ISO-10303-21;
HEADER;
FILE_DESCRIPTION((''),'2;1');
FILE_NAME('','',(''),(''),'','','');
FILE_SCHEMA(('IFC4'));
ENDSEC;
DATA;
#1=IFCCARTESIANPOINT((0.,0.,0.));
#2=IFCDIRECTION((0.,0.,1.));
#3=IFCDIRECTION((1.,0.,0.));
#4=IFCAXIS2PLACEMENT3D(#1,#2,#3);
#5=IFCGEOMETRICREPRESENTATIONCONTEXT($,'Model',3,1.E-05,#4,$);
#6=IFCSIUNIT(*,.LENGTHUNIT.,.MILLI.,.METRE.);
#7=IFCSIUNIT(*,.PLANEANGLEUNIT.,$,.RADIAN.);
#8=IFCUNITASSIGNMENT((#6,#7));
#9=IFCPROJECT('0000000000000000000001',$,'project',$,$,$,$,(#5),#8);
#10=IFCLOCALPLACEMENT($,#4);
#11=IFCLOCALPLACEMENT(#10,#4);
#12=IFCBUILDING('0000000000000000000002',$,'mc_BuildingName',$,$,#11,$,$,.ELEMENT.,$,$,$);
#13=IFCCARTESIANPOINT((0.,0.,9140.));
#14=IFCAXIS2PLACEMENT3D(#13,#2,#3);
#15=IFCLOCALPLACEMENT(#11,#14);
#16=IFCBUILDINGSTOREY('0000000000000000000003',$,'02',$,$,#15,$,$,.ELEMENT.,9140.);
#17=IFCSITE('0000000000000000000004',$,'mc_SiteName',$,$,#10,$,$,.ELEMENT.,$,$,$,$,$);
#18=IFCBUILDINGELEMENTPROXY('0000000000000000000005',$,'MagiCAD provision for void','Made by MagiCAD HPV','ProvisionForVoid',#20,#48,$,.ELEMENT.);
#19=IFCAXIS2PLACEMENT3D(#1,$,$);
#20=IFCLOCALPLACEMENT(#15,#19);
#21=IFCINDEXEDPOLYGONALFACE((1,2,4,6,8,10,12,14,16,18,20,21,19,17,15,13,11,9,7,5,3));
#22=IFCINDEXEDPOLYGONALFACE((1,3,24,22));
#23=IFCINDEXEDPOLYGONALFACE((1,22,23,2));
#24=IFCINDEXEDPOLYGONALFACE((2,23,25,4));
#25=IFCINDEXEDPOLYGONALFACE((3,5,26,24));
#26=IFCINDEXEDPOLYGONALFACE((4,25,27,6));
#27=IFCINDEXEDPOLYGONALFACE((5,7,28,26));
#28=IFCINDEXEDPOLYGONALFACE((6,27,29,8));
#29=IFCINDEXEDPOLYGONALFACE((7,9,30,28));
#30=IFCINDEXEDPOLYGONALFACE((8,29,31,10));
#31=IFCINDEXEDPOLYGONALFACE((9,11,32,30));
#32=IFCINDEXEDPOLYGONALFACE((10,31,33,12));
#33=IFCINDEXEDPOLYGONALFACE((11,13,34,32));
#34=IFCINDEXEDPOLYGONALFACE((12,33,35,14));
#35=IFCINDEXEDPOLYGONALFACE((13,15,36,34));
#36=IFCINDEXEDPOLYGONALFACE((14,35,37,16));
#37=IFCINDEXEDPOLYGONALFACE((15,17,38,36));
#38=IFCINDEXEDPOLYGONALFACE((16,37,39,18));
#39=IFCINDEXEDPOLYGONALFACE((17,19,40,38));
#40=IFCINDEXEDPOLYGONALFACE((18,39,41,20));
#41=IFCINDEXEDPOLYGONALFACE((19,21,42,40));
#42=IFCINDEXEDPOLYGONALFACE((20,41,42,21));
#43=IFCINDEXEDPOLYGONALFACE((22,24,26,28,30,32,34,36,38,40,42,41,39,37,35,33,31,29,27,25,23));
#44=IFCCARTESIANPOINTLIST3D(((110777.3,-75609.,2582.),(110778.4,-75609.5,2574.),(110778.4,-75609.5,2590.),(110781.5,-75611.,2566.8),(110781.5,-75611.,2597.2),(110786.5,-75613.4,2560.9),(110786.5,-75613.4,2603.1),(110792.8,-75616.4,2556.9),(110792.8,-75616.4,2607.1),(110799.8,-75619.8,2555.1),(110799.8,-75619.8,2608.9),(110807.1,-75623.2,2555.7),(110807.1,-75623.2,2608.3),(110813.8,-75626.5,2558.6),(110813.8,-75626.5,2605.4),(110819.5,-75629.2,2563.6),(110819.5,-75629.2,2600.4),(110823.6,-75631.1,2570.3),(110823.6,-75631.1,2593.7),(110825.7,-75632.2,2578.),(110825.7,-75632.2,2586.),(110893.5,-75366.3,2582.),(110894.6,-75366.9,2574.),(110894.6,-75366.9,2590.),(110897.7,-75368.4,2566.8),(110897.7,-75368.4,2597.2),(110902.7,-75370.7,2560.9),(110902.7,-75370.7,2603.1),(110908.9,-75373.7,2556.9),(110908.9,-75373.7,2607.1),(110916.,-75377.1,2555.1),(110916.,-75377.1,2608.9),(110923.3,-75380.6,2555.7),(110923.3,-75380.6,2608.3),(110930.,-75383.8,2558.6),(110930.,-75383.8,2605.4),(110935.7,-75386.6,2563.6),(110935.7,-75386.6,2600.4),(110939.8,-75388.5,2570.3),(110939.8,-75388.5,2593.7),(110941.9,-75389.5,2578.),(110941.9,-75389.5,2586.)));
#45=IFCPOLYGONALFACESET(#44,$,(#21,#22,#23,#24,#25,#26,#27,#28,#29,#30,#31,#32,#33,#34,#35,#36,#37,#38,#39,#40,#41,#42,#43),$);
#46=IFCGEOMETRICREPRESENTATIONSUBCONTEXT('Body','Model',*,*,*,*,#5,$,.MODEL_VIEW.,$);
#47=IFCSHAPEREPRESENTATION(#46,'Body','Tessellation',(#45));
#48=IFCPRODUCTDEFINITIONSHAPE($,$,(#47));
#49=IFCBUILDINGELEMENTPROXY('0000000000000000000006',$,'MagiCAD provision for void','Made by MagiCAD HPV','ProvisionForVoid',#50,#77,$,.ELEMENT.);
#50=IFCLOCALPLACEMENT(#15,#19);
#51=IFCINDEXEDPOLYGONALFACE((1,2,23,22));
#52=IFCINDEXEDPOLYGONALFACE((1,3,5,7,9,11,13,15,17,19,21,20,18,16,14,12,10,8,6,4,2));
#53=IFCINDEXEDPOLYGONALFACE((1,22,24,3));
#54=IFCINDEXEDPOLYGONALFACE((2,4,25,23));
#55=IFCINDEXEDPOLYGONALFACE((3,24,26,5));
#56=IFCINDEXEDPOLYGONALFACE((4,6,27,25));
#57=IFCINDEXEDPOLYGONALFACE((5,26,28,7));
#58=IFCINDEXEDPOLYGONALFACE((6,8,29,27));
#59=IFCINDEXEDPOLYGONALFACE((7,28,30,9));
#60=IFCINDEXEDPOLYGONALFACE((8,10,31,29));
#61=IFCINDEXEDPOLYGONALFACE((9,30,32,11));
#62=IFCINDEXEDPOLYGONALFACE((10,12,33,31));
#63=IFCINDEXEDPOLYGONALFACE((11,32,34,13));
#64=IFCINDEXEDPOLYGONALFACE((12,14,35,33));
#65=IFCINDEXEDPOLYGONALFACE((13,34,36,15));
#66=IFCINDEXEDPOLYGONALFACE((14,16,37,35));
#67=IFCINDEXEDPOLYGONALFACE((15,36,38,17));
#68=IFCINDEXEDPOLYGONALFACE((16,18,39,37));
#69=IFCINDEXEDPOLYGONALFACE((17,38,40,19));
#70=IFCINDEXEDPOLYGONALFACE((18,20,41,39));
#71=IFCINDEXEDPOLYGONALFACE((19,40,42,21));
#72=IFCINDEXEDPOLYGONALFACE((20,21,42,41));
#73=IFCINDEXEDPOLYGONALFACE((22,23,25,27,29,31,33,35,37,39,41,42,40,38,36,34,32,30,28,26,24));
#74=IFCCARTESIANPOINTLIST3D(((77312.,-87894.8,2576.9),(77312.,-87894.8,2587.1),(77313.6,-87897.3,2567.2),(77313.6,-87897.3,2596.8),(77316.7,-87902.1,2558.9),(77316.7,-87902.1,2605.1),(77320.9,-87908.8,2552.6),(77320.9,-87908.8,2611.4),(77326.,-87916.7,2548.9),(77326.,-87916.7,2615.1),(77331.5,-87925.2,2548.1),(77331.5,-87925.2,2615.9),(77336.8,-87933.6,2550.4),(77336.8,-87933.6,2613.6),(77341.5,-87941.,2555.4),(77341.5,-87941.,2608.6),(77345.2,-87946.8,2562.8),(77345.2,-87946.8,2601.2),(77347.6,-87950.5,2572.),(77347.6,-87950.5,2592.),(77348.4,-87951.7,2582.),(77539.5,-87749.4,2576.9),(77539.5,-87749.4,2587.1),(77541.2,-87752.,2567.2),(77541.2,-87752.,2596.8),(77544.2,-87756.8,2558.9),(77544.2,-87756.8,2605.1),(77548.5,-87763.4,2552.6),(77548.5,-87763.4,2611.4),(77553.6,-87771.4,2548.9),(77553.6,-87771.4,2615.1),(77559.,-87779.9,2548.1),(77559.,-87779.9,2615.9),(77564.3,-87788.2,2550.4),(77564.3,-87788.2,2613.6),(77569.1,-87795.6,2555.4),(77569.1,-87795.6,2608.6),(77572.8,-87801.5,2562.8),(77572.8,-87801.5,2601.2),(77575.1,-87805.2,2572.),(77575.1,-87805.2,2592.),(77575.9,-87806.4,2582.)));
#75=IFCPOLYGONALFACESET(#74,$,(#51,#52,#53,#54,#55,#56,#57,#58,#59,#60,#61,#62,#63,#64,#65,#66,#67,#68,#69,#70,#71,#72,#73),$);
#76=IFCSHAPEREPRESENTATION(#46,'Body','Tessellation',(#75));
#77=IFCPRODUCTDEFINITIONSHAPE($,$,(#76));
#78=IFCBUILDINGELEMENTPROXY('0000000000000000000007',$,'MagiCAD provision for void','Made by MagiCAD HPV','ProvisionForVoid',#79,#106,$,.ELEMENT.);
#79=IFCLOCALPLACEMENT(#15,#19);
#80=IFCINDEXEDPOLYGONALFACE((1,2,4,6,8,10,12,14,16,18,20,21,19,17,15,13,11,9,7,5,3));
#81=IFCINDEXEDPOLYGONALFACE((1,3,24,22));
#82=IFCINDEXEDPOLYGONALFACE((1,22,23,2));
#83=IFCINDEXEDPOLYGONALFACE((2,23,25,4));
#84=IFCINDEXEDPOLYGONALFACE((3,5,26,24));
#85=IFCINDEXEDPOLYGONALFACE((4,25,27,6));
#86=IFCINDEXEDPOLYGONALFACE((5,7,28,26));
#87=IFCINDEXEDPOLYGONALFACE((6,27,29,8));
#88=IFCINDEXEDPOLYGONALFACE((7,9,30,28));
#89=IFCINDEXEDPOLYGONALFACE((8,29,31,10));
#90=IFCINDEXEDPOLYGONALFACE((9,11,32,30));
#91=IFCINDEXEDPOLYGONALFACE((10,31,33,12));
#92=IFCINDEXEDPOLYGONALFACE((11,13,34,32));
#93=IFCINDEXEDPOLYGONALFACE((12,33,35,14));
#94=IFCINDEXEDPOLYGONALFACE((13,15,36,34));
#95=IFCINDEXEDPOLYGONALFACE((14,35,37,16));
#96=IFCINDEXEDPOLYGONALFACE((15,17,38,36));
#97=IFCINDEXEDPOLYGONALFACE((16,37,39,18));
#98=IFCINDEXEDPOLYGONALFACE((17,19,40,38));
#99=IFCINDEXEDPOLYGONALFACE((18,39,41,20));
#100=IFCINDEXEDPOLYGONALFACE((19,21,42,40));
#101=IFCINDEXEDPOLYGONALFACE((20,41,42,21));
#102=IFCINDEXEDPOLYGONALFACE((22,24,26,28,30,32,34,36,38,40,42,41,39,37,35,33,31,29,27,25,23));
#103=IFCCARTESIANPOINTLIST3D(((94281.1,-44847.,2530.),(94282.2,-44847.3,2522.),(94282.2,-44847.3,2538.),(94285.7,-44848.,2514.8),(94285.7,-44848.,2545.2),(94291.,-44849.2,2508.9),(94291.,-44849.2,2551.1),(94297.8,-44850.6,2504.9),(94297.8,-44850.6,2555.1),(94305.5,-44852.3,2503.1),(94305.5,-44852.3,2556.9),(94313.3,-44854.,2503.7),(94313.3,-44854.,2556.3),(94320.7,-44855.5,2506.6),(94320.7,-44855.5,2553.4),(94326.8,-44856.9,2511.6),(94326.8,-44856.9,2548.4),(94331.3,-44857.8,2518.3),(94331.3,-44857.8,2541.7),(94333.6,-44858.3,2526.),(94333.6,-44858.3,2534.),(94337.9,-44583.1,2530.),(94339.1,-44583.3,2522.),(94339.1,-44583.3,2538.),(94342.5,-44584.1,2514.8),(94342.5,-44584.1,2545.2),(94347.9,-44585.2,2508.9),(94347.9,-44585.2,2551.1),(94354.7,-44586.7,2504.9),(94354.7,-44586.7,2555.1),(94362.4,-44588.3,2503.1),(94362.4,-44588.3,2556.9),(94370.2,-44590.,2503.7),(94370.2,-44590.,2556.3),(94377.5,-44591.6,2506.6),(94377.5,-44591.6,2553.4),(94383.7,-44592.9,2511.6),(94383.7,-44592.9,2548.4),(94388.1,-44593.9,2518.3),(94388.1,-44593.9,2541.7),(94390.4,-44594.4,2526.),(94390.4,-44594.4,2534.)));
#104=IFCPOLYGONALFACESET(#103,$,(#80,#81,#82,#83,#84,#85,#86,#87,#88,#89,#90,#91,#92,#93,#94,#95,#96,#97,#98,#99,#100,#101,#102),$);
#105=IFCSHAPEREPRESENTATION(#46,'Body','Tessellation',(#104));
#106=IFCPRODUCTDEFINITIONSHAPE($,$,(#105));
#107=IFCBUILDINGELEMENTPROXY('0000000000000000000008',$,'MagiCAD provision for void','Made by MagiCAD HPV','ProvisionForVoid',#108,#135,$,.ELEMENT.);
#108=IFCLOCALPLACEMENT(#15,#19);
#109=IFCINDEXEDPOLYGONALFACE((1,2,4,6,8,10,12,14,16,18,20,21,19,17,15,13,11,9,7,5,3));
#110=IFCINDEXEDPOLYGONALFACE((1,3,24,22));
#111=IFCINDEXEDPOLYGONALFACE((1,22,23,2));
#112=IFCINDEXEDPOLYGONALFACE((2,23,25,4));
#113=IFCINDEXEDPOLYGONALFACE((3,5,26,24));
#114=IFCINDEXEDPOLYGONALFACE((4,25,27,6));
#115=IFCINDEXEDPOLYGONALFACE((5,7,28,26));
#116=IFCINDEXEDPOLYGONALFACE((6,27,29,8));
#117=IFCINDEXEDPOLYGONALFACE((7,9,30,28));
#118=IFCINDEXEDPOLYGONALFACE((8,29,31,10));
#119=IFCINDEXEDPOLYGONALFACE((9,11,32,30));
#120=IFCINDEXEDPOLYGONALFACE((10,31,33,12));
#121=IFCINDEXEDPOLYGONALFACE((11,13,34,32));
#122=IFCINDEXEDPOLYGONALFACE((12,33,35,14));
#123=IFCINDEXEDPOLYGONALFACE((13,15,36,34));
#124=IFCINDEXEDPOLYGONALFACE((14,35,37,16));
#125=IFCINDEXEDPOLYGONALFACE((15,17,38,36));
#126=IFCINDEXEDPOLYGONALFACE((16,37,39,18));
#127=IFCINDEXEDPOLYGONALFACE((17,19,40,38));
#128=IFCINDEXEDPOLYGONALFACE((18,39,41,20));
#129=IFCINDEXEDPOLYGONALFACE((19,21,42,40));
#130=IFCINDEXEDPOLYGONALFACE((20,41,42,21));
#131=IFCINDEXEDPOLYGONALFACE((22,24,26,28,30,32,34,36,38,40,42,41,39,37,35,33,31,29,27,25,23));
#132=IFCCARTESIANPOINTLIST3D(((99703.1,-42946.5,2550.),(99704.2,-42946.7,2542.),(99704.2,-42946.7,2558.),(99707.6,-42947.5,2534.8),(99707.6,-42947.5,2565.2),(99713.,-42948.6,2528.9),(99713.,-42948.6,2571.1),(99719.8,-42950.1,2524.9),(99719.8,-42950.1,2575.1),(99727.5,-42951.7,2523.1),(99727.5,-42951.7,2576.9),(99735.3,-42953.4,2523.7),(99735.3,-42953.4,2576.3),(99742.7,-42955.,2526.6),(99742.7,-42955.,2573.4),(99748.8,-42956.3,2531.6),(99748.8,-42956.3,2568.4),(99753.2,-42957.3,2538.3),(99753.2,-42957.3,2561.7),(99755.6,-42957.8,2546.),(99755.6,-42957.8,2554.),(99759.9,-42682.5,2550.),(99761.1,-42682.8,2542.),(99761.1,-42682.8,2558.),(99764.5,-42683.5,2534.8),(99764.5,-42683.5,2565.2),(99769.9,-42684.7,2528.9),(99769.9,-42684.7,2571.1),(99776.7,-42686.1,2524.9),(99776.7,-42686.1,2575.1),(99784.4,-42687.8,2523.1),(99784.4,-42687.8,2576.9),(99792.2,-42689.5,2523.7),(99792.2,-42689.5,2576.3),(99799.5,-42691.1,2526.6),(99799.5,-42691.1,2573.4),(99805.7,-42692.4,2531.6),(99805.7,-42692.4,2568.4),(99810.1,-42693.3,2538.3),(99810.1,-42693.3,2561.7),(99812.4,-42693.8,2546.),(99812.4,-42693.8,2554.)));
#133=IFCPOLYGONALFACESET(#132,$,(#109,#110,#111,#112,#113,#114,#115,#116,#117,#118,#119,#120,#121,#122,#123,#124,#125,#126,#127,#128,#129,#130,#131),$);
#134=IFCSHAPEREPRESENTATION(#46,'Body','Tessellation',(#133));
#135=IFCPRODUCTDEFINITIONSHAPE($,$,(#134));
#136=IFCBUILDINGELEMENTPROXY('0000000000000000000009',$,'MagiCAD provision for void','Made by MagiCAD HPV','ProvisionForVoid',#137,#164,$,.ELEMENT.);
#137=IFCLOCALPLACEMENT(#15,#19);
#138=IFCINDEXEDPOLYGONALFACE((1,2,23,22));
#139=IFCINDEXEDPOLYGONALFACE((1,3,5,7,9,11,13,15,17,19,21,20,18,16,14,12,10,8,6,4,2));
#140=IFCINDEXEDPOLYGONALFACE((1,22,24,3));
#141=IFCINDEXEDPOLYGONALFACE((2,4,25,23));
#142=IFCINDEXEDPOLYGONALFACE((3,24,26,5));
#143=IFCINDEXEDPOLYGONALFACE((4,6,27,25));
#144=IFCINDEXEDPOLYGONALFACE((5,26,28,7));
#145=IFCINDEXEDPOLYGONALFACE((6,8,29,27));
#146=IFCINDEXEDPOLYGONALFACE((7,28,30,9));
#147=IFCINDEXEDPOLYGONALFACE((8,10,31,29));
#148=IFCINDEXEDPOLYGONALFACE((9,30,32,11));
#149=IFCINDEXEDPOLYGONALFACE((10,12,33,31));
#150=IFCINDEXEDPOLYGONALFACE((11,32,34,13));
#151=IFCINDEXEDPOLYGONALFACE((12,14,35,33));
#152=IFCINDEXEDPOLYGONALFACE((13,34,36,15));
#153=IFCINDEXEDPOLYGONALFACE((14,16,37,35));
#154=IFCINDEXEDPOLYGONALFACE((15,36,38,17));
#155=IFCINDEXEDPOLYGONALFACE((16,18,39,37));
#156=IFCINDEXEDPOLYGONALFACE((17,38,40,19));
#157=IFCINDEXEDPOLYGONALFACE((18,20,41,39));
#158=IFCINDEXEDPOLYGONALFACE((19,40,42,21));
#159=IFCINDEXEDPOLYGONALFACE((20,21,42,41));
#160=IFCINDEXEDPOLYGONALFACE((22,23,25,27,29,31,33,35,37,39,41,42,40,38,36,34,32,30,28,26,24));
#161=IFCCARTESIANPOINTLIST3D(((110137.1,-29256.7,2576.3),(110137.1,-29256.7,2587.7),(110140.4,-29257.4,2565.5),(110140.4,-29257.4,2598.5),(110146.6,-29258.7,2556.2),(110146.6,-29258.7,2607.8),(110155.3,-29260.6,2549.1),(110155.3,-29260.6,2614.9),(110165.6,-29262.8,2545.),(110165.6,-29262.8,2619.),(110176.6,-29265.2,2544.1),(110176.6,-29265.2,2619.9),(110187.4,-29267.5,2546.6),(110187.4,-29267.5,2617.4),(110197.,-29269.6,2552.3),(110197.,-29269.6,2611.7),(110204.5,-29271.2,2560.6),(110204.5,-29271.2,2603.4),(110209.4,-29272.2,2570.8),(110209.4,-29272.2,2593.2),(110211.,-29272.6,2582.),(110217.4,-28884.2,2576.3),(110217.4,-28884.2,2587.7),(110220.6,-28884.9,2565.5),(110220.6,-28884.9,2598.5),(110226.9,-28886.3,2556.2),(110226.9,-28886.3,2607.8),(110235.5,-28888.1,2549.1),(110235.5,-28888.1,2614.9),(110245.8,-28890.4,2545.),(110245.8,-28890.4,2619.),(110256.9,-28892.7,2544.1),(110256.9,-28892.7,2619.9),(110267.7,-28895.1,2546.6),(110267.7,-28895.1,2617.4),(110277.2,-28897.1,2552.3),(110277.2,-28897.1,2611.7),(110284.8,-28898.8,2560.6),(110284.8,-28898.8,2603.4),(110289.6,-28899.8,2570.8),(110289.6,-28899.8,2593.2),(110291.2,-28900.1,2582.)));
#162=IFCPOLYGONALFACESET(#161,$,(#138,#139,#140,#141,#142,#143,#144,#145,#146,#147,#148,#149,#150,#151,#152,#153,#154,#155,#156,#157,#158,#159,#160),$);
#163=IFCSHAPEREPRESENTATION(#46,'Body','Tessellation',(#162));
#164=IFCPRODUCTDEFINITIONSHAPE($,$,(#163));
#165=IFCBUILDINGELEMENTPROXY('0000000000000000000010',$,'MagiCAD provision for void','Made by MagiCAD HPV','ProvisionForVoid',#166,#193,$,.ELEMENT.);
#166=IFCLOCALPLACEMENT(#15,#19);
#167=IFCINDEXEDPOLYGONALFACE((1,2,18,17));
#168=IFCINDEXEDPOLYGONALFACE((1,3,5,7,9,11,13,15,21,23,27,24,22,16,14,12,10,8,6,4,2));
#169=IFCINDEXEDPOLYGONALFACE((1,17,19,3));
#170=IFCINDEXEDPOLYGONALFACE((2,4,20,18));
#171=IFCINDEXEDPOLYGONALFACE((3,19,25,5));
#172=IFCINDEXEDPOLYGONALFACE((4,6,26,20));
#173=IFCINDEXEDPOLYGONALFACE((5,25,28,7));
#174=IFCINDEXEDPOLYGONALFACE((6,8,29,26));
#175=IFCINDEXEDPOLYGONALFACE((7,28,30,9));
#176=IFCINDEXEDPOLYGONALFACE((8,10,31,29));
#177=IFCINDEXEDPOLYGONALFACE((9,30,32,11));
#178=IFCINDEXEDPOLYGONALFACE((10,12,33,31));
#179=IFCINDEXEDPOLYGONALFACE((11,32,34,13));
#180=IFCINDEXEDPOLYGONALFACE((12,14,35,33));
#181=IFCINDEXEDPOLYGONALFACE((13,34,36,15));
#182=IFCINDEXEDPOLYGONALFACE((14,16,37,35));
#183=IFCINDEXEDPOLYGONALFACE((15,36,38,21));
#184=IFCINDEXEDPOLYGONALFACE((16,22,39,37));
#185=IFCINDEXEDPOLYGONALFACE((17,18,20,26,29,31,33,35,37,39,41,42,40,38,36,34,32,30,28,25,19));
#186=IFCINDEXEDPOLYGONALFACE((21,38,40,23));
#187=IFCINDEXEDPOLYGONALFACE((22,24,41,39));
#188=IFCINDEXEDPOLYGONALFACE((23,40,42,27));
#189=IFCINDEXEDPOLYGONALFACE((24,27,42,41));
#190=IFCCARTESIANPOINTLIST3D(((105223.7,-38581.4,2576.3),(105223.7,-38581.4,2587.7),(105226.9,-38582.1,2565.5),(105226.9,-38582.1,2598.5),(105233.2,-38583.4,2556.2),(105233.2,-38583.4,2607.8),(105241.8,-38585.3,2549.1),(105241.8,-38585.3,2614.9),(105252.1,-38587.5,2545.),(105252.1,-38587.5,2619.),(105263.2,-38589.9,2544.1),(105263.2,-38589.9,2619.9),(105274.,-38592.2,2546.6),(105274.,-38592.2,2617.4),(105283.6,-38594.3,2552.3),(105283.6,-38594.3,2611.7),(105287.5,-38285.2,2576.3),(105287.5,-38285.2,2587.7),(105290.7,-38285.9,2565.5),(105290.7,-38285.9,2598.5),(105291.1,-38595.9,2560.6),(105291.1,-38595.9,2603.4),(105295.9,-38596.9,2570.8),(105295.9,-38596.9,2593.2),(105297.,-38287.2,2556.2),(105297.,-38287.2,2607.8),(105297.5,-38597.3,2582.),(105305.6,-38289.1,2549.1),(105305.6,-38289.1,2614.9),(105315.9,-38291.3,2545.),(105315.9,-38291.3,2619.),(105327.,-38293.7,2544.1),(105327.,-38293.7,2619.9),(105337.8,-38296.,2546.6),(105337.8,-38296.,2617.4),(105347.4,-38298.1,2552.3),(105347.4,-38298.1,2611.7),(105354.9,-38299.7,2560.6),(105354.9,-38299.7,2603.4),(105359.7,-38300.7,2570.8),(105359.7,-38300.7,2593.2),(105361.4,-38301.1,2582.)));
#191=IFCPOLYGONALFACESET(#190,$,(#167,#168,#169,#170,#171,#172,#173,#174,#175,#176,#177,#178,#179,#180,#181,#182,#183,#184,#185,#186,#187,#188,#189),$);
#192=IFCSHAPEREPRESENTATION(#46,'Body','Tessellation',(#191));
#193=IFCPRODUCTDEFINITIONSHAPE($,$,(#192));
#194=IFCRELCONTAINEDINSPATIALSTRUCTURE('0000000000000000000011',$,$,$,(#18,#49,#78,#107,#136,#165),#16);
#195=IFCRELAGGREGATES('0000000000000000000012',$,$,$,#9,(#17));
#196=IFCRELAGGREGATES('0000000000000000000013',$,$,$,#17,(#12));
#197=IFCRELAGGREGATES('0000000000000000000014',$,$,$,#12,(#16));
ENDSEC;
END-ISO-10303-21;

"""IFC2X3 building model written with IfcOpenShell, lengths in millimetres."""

from ifc_helpers import new_model, si_unit, frame, origin_with_axes, origin_2d_with_axis, place, context, subcontext, project, spatial, circle, extrude, source, transform, mapped, element, save


model = new_model("IFC2X3")

# Units and contexts
model_context = context("Model", 3, precision=1e-05, world=origin_with_axes())
body_context = subcontext(model_context, "Body", "Model", "MODEL_VIEW")
ifc_project = project(units=[si_unit("LENGTHUNIT", "METRE", prefix="MILLI"), si_unit("PLANEANGLEUNIT", "RADIAN")], contexts=[model_context])

# Site, building, storey
site_placement = place(None, origin_with_axes())
site = spatial("IfcSite", under=ifc_project, at=site_placement, Name="mc_SiteName", CompositionType="ELEMENT")
building_placement = place(site_placement, origin_with_axes())
building = spatial("IfcBuilding", under=site, at=building_placement, Name="mc_BuildingName", CompositionType="ELEMENT")
storey_placement = place(building_placement, frame((0.0, 0.0, 9140.0), z_axis=(0.0, 0.0, 1.0), x_axis=(1.0, 0.0, 0.0)))
storey = spatial("IfcBuildingStorey", under=building, at=storey_placement, Name="02", CompositionType="ELEMENT", Elevation=9140.0)

# Building element proxies
shared_shape_1 = source(origin_with_axes(), body_context, "Body", "SweptSolid", [
    extrude(circle(Radius=27.0, at=origin_2d_with_axis()), frame((0.0, 0.0, 0.0), z_axis=(1.0, 0.0, 0.0), x_axis=(0.0, 1.0, 0.0)), (0.0, 0.0, 1.0), 269.0),
])
proxy_1_placement = place(storey_placement, frame((110801.7, -75620.6, 2582.0), z_axis=(0.0, 0.0, 1.0), x_axis=(0.431859, 0.901941, 0.0)))
element("IfcBuildingElementProxy", 1, at=proxy_1_placement, inside=storey, Name="MagiCAD provision for void", Description="Made by MagiCAD HPV", ObjectType="ProvisionForVoid", CompositionType="ELEMENT", context=body_context, shape_type="MappedRepresentation", body=[
    mapped(shared_shape_1, transform((0.0, 0.0, 0.0), scale=1.0)),
])
shared_shape_2 = source(origin_with_axes(), body_context, "Body", "SweptSolid", [
    extrude(circle(Radius=34.0, at=origin_2d_with_axis()), frame((0.0, 0.0, 0.0), z_axis=(1.0, 0.0, 0.0), x_axis=(0.0, 1.0, 0.0)), (0.0, 0.0, 1.0), 270.0),
])
proxy_2_placement = place(storey_placement, frame((77557.6, -87777.8, 2582.0), z_axis=(0.0, 0.0, 1.0), x_axis=(-0.842809, -0.538213, 0.0)))
element("IfcBuildingElementProxy", 2, at=proxy_2_placement, inside=storey, Name="MagiCAD provision for void", Description="Made by MagiCAD HPV", ObjectType="ProvisionForVoid", CompositionType="ELEMENT", context=body_context, shape_type="MappedRepresentation", body=[
    mapped(shared_shape_2, transform((0.0, 0.0, 0.0), scale=1.0)),
])
shared_shape_3 = source(origin_with_axes(), body_context, "Body", "SweptSolid", [
    extrude(circle(Radius=27.0, at=origin_2d_with_axis()), frame((0.0, 0.0, 0.0), z_axis=(1.0, 0.0, 0.0), x_axis=(0.0, 1.0, 0.0)), (0.0, 0.0, 1.0), 270.0),
])
proxy_3_placement = place(storey_placement, frame((94307.5, -44852.7, 2530.0), z_axis=(0.0, 0.0, 1.0), x_axis=(0.210642, 0.977563, 0.0)))
element("IfcBuildingElementProxy", 3, at=proxy_3_placement, inside=storey, Name="MagiCAD provision for void", Description="Made by MagiCAD HPV", ObjectType="ProvisionForVoid", CompositionType="ELEMENT", context=body_context, shape_type="MappedRepresentation", body=[
    mapped(shared_shape_3, transform((0.0, 0.0, 0.0), scale=1.0)),
])
shared_shape_4 = source(origin_with_axes(), body_context, "Body", "SweptSolid", [
    extrude(circle(Radius=27.0, at=origin_2d_with_axis()), frame((0.0, 0.0, 0.0), z_axis=(1.0, 0.0, 0.0), x_axis=(0.0, 1.0, 0.0)), (0.0, 0.0, 1.0), 270.0),
])
proxy_4_placement = place(storey_placement, frame((99729.5, -42952.2, 2550.0), z_axis=(0.0, 0.0, 1.0), x_axis=(0.210642, 0.977563, 0.0)))
element("IfcBuildingElementProxy", 4, at=proxy_4_placement, inside=storey, Name="MagiCAD provision for void", Description="Made by MagiCAD HPV", ObjectType="ProvisionForVoid", CompositionType="ELEMENT", context=body_context, shape_type="MappedRepresentation", body=[
    mapped(shared_shape_4, transform((0.0, 0.0, 0.0), scale=1.0)),
])
shared_shape_5 = source(origin_with_axes(), body_context, "Body", "SweptSolid", [
    extrude(circle(Radius=38.0, at=origin_2d_with_axis()), frame((0.0, 0.0, 0.0), z_axis=(1.0, 0.0, 0.0), x_axis=(0.0, 1.0, 0.0)), (0.0, 0.0, 1.0), 381.0),
])
proxy_5_placement = place(storey_placement, frame((110254.1, -28892.1, 2582.0), z_axis=(0.0, 0.0, 1.0), x_axis=(-0.210582, -0.977576, 0.0)))
element("IfcBuildingElementProxy", 5, at=proxy_5_placement, inside=storey, Name="MagiCAD provision for void", Description="Made by MagiCAD HPV", ObjectType="ProvisionForVoid", CompositionType="ELEMENT", context=body_context, shape_type="MappedRepresentation", body=[
    mapped(shared_shape_5, transform((0.0, 0.0, 0.0), scale=1.0)),
])
shared_shape_6 = source(origin_with_axes(), body_context, "Body", "SweptSolid", [
    extrude(circle(Radius=38.0, at=origin_2d_with_axis()), frame((0.0, 0.0, 0.0), z_axis=(1.0, 0.0, 0.0), x_axis=(0.0, 1.0, 0.0)), (0.0, 0.0, 1.0), 303.0),
])
proxy_6_placement = place(storey_placement, frame((105324.2, -38293.1, 2582.0), z_axis=(0.0, 0.0, 1.0), x_axis=(-0.210582, -0.977576, 0.0)))
element("IfcBuildingElementProxy", 6, at=proxy_6_placement, inside=storey, Name="MagiCAD provision for void", Description="Made by MagiCAD HPV", ObjectType="ProvisionForVoid", CompositionType="ELEMENT", context=body_context, shape_type="MappedRepresentation", body=[
    mapped(shared_shape_6, transform((0.0, 0.0, 0.0), scale=1.0)),
])

save(model, "model.ifc")
